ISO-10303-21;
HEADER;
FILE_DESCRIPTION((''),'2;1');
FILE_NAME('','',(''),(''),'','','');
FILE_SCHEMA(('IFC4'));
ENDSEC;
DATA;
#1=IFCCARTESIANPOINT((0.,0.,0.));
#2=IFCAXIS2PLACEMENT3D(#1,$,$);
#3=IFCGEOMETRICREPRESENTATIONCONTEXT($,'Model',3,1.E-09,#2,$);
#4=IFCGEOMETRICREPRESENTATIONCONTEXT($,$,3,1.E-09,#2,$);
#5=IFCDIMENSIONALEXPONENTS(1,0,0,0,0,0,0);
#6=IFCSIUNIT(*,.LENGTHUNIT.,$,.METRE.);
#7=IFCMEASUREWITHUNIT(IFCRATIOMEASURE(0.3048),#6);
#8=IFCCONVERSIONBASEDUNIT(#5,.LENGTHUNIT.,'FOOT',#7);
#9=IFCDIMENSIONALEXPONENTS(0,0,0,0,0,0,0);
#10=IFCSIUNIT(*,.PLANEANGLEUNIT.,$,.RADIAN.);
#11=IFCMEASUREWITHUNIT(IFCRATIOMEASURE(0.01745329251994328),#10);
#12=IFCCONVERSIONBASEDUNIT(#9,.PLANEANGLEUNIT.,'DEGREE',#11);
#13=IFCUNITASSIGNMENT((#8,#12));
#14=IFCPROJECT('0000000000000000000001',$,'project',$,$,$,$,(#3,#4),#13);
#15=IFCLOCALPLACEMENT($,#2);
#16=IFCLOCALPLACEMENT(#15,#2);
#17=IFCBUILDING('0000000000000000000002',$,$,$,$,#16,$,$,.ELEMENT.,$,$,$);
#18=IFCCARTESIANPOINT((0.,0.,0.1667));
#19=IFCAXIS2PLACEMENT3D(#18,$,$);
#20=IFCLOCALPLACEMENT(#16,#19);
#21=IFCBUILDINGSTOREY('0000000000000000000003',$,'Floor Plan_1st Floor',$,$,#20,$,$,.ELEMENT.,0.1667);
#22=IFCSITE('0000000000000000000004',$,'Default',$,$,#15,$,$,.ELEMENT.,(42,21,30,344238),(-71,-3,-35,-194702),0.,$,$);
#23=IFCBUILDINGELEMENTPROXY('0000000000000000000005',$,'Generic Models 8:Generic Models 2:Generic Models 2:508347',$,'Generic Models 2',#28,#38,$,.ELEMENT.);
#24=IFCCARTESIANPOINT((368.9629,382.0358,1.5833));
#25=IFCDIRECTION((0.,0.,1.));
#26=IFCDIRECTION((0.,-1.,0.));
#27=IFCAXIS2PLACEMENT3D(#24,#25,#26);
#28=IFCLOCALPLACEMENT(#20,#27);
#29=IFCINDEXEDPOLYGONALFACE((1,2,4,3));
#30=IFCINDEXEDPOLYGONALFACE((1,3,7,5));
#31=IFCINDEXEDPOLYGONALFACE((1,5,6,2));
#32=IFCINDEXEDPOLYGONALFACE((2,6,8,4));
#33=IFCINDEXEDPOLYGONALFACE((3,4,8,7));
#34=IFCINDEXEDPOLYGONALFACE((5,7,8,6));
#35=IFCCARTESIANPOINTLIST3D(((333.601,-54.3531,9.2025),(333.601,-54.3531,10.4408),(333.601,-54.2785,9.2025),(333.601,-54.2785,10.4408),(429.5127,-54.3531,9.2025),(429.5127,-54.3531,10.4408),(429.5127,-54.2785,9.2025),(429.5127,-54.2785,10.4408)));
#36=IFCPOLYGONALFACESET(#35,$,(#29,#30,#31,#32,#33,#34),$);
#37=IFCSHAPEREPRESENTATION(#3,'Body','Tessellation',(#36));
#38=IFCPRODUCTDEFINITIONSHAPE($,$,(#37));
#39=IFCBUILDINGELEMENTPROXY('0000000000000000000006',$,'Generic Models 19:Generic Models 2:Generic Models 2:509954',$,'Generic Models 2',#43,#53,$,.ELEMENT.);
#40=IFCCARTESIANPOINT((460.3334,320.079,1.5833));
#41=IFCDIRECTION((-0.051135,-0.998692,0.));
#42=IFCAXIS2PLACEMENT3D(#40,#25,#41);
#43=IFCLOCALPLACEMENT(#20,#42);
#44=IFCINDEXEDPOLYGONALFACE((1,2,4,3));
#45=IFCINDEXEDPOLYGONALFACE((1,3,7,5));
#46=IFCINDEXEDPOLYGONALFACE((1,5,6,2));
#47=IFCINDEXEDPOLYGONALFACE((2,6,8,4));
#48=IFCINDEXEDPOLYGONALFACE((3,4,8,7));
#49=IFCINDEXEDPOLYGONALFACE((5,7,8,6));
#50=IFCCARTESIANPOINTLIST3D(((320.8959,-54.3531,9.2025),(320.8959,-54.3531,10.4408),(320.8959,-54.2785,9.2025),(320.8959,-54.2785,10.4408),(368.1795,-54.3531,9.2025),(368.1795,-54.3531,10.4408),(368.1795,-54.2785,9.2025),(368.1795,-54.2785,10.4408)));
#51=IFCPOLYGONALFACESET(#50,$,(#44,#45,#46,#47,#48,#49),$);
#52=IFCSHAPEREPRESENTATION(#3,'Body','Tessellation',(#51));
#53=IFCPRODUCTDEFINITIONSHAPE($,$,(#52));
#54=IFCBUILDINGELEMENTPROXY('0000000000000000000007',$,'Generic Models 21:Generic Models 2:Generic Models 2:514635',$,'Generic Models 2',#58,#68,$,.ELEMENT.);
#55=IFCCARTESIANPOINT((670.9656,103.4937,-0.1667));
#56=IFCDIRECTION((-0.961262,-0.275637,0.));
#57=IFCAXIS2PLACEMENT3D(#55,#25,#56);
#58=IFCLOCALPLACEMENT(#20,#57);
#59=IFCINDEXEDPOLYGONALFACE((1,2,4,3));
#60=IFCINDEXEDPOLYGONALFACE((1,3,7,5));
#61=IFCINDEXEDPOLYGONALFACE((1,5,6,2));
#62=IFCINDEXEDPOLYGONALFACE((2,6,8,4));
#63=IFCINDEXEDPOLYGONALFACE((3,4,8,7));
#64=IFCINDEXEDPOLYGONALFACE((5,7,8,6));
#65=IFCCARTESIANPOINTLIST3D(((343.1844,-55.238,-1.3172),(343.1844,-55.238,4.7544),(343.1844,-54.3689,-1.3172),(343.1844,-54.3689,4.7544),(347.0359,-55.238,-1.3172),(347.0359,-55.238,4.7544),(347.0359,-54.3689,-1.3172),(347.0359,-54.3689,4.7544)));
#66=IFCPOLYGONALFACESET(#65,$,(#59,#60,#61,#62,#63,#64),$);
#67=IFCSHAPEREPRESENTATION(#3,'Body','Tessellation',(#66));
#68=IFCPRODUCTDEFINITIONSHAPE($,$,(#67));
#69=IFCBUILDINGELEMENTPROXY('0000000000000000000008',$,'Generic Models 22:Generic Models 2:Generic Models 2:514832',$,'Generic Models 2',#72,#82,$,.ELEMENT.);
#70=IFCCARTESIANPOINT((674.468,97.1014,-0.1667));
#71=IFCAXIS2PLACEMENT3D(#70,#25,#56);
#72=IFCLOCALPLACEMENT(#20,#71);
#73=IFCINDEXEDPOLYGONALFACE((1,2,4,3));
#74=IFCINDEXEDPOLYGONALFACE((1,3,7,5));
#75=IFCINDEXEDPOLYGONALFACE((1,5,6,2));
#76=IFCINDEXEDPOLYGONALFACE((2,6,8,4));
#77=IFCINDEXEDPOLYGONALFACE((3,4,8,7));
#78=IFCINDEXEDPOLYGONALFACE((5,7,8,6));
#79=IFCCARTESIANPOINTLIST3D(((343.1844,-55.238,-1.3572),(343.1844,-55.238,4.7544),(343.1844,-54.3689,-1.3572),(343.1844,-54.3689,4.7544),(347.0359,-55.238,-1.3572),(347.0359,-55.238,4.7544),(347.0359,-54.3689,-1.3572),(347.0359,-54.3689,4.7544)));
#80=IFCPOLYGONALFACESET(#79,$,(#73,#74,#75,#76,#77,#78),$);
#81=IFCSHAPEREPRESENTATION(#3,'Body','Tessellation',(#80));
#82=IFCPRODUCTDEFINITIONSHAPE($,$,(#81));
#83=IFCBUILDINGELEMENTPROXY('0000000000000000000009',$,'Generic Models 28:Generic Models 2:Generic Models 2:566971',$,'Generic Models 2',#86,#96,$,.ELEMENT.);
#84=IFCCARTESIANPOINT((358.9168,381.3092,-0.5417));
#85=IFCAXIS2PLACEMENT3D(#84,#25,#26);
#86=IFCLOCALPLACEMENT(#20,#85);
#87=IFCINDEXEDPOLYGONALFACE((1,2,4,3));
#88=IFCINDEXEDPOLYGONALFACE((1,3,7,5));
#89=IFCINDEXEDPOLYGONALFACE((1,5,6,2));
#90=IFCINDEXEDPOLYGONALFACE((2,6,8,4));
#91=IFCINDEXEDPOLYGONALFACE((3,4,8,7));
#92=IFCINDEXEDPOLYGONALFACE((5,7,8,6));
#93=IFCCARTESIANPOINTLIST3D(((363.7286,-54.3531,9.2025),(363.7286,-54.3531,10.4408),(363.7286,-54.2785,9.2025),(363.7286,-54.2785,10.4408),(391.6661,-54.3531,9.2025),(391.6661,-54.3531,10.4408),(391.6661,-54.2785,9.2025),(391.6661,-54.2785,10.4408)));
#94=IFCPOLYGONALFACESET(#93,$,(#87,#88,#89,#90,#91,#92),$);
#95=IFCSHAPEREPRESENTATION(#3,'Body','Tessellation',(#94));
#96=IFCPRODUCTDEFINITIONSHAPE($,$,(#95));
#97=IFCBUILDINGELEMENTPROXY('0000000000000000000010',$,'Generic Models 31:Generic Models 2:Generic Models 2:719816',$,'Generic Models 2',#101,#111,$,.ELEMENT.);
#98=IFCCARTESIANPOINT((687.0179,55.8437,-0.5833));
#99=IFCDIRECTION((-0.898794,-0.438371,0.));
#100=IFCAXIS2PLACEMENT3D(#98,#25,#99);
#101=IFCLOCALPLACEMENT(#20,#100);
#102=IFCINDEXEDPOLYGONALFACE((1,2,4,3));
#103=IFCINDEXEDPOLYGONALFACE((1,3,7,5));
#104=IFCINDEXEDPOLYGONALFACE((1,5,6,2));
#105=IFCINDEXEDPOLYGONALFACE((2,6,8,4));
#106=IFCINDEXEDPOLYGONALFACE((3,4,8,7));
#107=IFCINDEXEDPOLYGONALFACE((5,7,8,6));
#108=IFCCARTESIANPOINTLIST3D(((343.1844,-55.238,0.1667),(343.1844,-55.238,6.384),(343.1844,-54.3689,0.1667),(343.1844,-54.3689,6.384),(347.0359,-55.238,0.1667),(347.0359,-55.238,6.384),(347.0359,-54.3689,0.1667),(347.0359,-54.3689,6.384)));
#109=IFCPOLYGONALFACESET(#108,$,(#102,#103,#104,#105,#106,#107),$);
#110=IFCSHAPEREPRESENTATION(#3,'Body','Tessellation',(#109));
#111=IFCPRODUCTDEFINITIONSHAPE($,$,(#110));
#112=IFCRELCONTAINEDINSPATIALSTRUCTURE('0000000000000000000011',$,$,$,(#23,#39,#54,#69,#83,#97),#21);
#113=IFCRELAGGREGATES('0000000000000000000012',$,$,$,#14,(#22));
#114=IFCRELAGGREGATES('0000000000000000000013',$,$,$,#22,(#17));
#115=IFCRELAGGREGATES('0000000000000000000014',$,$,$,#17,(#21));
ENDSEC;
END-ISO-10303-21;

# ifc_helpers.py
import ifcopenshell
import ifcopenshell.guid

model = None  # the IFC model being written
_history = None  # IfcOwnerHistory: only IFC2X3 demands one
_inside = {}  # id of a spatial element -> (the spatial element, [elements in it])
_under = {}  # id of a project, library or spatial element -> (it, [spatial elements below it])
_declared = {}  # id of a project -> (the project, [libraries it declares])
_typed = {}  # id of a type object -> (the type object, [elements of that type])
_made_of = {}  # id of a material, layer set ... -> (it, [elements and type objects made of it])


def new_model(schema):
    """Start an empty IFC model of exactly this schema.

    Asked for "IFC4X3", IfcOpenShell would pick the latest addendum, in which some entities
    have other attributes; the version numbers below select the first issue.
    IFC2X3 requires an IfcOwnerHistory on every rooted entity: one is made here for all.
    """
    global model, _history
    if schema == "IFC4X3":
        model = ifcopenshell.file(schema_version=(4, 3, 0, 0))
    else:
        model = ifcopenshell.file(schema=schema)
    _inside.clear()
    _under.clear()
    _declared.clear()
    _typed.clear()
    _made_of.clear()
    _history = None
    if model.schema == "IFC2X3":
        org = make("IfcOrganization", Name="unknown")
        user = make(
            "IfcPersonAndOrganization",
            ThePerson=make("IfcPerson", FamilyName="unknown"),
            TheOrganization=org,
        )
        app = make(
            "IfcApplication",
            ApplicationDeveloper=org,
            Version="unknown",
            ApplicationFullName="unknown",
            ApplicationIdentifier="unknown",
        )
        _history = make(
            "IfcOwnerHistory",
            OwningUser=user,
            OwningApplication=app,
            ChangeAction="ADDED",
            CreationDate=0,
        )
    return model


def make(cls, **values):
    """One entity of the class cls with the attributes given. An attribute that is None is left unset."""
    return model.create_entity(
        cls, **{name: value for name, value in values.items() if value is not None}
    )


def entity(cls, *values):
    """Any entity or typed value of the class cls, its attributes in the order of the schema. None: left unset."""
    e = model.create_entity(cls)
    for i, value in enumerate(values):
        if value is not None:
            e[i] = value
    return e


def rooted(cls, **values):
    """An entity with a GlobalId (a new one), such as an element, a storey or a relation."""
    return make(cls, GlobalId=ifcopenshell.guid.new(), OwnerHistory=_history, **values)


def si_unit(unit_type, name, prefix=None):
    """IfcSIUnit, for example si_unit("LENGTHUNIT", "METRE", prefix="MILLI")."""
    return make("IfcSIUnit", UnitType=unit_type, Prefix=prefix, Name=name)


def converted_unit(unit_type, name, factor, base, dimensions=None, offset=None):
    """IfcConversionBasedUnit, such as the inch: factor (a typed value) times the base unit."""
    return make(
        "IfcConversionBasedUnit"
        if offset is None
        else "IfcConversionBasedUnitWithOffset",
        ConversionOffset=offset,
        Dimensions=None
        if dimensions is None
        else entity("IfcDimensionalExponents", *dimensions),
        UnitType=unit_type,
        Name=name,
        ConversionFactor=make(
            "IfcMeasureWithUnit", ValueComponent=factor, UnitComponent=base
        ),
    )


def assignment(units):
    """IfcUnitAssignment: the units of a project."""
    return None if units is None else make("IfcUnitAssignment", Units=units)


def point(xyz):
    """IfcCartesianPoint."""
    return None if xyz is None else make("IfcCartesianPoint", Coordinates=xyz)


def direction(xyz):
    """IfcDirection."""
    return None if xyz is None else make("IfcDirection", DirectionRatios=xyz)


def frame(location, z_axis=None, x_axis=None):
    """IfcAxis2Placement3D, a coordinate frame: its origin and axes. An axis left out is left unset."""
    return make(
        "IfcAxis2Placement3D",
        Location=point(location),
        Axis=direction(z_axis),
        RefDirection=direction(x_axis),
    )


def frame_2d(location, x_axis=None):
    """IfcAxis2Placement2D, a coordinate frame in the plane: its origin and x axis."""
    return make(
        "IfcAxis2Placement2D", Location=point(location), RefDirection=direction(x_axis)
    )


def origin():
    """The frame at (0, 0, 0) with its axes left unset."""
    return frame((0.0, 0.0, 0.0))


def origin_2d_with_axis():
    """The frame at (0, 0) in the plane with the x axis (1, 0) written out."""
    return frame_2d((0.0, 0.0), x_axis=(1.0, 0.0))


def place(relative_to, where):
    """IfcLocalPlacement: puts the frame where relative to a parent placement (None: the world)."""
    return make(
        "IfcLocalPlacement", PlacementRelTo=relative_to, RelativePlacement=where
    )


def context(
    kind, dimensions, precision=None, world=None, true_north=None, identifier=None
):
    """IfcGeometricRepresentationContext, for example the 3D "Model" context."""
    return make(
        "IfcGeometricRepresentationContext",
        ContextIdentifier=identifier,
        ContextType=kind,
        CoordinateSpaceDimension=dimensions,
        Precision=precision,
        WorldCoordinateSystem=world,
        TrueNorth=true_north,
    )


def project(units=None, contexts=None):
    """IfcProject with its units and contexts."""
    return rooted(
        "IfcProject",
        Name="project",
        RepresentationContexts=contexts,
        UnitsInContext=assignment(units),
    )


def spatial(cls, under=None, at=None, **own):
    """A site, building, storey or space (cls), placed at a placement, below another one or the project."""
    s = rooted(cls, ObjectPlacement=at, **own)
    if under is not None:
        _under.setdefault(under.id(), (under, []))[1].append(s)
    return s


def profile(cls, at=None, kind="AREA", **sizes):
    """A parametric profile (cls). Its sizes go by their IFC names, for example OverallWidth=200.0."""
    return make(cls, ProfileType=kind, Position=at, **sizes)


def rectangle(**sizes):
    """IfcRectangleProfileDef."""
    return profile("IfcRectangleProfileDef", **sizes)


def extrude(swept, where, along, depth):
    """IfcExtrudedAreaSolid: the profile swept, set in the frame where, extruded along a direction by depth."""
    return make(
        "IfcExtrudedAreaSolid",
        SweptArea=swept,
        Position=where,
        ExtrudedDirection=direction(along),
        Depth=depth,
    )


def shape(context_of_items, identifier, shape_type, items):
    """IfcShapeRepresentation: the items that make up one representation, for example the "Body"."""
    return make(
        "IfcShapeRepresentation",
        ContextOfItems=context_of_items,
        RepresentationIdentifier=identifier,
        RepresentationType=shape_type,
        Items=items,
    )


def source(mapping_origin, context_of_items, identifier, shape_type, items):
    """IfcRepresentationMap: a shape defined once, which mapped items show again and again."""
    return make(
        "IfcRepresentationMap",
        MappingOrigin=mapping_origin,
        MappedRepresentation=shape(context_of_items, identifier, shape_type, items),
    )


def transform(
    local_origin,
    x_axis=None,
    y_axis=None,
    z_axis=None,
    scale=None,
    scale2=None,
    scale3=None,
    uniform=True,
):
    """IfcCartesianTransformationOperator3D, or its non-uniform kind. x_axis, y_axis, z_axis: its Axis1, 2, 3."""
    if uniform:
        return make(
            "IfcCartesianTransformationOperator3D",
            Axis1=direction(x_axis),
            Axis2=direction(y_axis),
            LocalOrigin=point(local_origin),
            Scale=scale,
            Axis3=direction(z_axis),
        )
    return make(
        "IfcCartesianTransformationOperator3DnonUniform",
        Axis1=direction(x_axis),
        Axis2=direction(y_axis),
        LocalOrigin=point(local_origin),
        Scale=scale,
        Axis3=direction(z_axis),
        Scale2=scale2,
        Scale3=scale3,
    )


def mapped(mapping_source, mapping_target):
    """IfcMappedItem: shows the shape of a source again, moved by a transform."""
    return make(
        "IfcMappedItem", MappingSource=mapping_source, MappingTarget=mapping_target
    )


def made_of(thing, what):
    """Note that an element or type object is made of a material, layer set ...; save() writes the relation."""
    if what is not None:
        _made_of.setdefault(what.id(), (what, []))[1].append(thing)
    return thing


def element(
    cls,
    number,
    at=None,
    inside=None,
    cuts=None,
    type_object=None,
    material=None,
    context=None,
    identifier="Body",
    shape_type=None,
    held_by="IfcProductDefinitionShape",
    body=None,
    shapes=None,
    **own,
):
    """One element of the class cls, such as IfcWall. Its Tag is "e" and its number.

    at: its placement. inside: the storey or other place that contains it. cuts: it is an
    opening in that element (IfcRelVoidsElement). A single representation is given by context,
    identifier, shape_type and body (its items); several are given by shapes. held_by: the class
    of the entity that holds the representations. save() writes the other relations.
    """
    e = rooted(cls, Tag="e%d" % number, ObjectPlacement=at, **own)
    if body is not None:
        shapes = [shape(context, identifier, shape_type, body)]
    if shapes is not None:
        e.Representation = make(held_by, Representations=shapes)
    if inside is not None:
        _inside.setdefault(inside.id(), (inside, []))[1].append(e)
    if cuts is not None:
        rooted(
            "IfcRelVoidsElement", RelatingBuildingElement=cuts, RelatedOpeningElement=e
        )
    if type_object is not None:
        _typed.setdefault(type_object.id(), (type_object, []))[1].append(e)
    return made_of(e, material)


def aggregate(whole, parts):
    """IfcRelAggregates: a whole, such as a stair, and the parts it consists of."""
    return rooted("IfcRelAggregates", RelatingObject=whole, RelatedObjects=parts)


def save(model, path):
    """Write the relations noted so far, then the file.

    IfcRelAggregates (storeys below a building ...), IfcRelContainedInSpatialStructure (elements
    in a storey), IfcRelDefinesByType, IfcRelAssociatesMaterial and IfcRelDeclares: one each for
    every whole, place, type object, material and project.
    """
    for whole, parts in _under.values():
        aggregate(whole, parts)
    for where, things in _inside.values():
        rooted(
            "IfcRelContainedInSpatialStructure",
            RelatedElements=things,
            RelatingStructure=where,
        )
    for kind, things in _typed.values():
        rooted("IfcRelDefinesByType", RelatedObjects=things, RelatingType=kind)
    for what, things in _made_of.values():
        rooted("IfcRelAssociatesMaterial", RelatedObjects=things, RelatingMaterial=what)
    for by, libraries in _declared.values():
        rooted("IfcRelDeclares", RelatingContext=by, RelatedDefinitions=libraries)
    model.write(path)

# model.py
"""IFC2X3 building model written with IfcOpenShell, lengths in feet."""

from ifc_helpers import new_model, entity, si_unit, converted_unit, frame, origin, origin_2d_with_axis, place, context, project, spatial, rectangle, extrude, source, transform, mapped, element, save


model = new_model("IFC2X3")

# Units and contexts
model_context = context("Model", 3, precision=1e-09, world=origin())
context_of_model = context(None, 3, precision=1e-09, world=origin())
ifc_project = project(units=[converted_unit("LENGTHUNIT", "FOOT", entity("IfcRatioMeasure", 0.3048), si_unit("LENGTHUNIT", "METRE"), dimensions=[1, 0, 0, 0, 0, 0, 0]), converted_unit("PLANEANGLEUNIT", "DEGREE", entity("IfcRatioMeasure", 0.01745329251994328), si_unit("PLANEANGLEUNIT", "RADIAN"), dimensions=[0, 0, 0, 0, 0, 0, 0])], contexts=[model_context, context_of_model])

# Site, building, storey
site_placement = place(None, origin())
site = spatial("IfcSite", under=ifc_project, at=site_placement, Name="Default", CompositionType="ELEMENT", RefLatitude=(42, 21, 30, 344238), RefLongitude=(-71, -3, -35, -194702), RefElevation=0.0)
building_placement = place(site_placement, origin())
building = spatial("IfcBuilding", under=site, at=building_placement, CompositionType="ELEMENT")
storey_placement = place(building_placement, frame((0.0, 0.0, 0.1667)))
storey = spatial("IfcBuildingStorey", under=building, at=storey_placement, Name="Floor Plan_1st Floor", CompositionType="ELEMENT", Elevation=0.1667)

# Building element proxies
shared_shape_1 = source(origin(), model_context, "Body", "SweptSolid", [
    extrude(rectangle(XDim=95.9117, YDim=0.0746, at=origin_2d_with_axis()), frame((381.5568, -54.3158, 9.2025)), (0.0, 0.0, 1.0), 1.2382),
])
proxy_1_placement = place(storey_placement, frame((368.9629, 382.0358, 1.5833), z_axis=(0.0, 0.0, 1.0), x_axis=(0.0, -1.0, 0.0)))
element("IfcBuildingElementProxy", 1, at=proxy_1_placement, inside=storey, Name="Generic Models 8:Generic Models 2:Generic Models 2:508347", ObjectType="Generic Models 2", CompositionType="ELEMENT", context=model_context, shape_type="MappedRepresentation", body=[
    mapped(shared_shape_1, transform((0.0, 0.0, 0.0), scale=1.0)),
])
shared_shape_2 = source(origin(), model_context, "Body", "SweptSolid", [
    extrude(rectangle(XDim=47.2836, YDim=0.0746, at=origin_2d_with_axis()), frame((344.5377, -54.3158, 9.2025)), (0.0, 0.0, 1.0), 1.2382),
])
proxy_2_placement = place(storey_placement, frame((460.3334, 320.079, 1.5833), z_axis=(0.0, 0.0, 1.0), x_axis=(-0.051135, -0.998692, 0.0)))
element("IfcBuildingElementProxy", 2, at=proxy_2_placement, inside=storey, Name="Generic Models 19:Generic Models 2:Generic Models 2:509954", ObjectType="Generic Models 2", CompositionType="ELEMENT", context=model_context, shape_type="MappedRepresentation", body=[
    mapped(shared_shape_2, transform((0.0, 0.0, 0.0), scale=1.0)),
])
shared_shape_3 = source(origin(), model_context, "Body", "SweptSolid", [
    extrude(rectangle(XDim=3.8516, YDim=0.8691, at=origin_2d_with_axis()), frame((345.1101, -54.8035, -1.3172)), (0.0, 0.0, 1.0), 6.0716),
])
proxy_3_placement = place(storey_placement, frame((670.9656, 103.4937, -0.1667), z_axis=(0.0, 0.0, 1.0), x_axis=(-0.961262, -0.275637, 0.0)))
element("IfcBuildingElementProxy", 3, at=proxy_3_placement, inside=storey, Name="Generic Models 21:Generic Models 2:Generic Models 2:514635", ObjectType="Generic Models 2", CompositionType="ELEMENT", context=model_context, shape_type="MappedRepresentation", body=[
    mapped(shared_shape_3, transform((0.0, 0.0, 0.0), scale=1.0)),
])
shared_shape_4 = source(origin(), model_context, "Body", "SweptSolid", [
    extrude(rectangle(XDim=3.8516, YDim=0.8691, at=origin_2d_with_axis()), frame((345.1101, -54.8035, -1.3572)), (0.0, 0.0, 1.0), 6.1116),
])
proxy_4_placement = place(storey_placement, frame((674.468, 97.1014, -0.1667), z_axis=(0.0, 0.0, 1.0), x_axis=(-0.961262, -0.275637, 0.0)))
element("IfcBuildingElementProxy", 4, at=proxy_4_placement, inside=storey, Name="Generic Models 22:Generic Models 2:Generic Models 2:514832", ObjectType="Generic Models 2", CompositionType="ELEMENT", context=model_context, shape_type="MappedRepresentation", body=[
    mapped(shared_shape_4, transform((0.0, 0.0, 0.0), scale=1.0)),
])
shared_shape_5 = source(origin(), model_context, "Body", "SweptSolid", [
    extrude(rectangle(XDim=27.9375, YDim=0.0746, at=origin_2d_with_axis()), frame((377.6973, -54.3158, 9.2025)), (0.0, 0.0, 1.0), 1.2382),
])
proxy_5_placement = place(storey_placement, frame((358.9168, 381.3092, -0.5417), z_axis=(0.0, 0.0, 1.0), x_axis=(0.0, -1.0, 0.0)))
element("IfcBuildingElementProxy", 5, at=proxy_5_placement, inside=storey, Name="Generic Models 28:Generic Models 2:Generic Models 2:566971", ObjectType="Generic Models 2", CompositionType="ELEMENT", context=model_context, shape_type="MappedRepresentation", body=[
    mapped(shared_shape_5, transform((0.0, 0.0, 0.0), scale=1.0)),
])
shared_shape_6 = source(origin(), model_context, "Body", "SweptSolid", [
    extrude(rectangle(XDim=3.8516, YDim=0.8691, at=origin_2d_with_axis()), frame((345.1101, -54.8035, 0.1667)), (0.0, 0.0, 1.0), 6.2173),
])
proxy_6_placement = place(storey_placement, frame((687.0179, 55.8437, -0.5833), z_axis=(0.0, 0.0, 1.0), x_axis=(-0.898794, -0.438371, 0.0)))
element("IfcBuildingElementProxy", 6, at=proxy_6_placement, inside=storey, Name="Generic Models 31:Generic Models 2:Generic Models 2:719816", ObjectType="Generic Models 2", CompositionType="ELEMENT", context=model_context, shape_type="MappedRepresentation", body=[
    mapped(shared_shape_6, transform((0.0, 0.0, 0.0), scale=1.0)),
])

save(model, "model.ifc")
